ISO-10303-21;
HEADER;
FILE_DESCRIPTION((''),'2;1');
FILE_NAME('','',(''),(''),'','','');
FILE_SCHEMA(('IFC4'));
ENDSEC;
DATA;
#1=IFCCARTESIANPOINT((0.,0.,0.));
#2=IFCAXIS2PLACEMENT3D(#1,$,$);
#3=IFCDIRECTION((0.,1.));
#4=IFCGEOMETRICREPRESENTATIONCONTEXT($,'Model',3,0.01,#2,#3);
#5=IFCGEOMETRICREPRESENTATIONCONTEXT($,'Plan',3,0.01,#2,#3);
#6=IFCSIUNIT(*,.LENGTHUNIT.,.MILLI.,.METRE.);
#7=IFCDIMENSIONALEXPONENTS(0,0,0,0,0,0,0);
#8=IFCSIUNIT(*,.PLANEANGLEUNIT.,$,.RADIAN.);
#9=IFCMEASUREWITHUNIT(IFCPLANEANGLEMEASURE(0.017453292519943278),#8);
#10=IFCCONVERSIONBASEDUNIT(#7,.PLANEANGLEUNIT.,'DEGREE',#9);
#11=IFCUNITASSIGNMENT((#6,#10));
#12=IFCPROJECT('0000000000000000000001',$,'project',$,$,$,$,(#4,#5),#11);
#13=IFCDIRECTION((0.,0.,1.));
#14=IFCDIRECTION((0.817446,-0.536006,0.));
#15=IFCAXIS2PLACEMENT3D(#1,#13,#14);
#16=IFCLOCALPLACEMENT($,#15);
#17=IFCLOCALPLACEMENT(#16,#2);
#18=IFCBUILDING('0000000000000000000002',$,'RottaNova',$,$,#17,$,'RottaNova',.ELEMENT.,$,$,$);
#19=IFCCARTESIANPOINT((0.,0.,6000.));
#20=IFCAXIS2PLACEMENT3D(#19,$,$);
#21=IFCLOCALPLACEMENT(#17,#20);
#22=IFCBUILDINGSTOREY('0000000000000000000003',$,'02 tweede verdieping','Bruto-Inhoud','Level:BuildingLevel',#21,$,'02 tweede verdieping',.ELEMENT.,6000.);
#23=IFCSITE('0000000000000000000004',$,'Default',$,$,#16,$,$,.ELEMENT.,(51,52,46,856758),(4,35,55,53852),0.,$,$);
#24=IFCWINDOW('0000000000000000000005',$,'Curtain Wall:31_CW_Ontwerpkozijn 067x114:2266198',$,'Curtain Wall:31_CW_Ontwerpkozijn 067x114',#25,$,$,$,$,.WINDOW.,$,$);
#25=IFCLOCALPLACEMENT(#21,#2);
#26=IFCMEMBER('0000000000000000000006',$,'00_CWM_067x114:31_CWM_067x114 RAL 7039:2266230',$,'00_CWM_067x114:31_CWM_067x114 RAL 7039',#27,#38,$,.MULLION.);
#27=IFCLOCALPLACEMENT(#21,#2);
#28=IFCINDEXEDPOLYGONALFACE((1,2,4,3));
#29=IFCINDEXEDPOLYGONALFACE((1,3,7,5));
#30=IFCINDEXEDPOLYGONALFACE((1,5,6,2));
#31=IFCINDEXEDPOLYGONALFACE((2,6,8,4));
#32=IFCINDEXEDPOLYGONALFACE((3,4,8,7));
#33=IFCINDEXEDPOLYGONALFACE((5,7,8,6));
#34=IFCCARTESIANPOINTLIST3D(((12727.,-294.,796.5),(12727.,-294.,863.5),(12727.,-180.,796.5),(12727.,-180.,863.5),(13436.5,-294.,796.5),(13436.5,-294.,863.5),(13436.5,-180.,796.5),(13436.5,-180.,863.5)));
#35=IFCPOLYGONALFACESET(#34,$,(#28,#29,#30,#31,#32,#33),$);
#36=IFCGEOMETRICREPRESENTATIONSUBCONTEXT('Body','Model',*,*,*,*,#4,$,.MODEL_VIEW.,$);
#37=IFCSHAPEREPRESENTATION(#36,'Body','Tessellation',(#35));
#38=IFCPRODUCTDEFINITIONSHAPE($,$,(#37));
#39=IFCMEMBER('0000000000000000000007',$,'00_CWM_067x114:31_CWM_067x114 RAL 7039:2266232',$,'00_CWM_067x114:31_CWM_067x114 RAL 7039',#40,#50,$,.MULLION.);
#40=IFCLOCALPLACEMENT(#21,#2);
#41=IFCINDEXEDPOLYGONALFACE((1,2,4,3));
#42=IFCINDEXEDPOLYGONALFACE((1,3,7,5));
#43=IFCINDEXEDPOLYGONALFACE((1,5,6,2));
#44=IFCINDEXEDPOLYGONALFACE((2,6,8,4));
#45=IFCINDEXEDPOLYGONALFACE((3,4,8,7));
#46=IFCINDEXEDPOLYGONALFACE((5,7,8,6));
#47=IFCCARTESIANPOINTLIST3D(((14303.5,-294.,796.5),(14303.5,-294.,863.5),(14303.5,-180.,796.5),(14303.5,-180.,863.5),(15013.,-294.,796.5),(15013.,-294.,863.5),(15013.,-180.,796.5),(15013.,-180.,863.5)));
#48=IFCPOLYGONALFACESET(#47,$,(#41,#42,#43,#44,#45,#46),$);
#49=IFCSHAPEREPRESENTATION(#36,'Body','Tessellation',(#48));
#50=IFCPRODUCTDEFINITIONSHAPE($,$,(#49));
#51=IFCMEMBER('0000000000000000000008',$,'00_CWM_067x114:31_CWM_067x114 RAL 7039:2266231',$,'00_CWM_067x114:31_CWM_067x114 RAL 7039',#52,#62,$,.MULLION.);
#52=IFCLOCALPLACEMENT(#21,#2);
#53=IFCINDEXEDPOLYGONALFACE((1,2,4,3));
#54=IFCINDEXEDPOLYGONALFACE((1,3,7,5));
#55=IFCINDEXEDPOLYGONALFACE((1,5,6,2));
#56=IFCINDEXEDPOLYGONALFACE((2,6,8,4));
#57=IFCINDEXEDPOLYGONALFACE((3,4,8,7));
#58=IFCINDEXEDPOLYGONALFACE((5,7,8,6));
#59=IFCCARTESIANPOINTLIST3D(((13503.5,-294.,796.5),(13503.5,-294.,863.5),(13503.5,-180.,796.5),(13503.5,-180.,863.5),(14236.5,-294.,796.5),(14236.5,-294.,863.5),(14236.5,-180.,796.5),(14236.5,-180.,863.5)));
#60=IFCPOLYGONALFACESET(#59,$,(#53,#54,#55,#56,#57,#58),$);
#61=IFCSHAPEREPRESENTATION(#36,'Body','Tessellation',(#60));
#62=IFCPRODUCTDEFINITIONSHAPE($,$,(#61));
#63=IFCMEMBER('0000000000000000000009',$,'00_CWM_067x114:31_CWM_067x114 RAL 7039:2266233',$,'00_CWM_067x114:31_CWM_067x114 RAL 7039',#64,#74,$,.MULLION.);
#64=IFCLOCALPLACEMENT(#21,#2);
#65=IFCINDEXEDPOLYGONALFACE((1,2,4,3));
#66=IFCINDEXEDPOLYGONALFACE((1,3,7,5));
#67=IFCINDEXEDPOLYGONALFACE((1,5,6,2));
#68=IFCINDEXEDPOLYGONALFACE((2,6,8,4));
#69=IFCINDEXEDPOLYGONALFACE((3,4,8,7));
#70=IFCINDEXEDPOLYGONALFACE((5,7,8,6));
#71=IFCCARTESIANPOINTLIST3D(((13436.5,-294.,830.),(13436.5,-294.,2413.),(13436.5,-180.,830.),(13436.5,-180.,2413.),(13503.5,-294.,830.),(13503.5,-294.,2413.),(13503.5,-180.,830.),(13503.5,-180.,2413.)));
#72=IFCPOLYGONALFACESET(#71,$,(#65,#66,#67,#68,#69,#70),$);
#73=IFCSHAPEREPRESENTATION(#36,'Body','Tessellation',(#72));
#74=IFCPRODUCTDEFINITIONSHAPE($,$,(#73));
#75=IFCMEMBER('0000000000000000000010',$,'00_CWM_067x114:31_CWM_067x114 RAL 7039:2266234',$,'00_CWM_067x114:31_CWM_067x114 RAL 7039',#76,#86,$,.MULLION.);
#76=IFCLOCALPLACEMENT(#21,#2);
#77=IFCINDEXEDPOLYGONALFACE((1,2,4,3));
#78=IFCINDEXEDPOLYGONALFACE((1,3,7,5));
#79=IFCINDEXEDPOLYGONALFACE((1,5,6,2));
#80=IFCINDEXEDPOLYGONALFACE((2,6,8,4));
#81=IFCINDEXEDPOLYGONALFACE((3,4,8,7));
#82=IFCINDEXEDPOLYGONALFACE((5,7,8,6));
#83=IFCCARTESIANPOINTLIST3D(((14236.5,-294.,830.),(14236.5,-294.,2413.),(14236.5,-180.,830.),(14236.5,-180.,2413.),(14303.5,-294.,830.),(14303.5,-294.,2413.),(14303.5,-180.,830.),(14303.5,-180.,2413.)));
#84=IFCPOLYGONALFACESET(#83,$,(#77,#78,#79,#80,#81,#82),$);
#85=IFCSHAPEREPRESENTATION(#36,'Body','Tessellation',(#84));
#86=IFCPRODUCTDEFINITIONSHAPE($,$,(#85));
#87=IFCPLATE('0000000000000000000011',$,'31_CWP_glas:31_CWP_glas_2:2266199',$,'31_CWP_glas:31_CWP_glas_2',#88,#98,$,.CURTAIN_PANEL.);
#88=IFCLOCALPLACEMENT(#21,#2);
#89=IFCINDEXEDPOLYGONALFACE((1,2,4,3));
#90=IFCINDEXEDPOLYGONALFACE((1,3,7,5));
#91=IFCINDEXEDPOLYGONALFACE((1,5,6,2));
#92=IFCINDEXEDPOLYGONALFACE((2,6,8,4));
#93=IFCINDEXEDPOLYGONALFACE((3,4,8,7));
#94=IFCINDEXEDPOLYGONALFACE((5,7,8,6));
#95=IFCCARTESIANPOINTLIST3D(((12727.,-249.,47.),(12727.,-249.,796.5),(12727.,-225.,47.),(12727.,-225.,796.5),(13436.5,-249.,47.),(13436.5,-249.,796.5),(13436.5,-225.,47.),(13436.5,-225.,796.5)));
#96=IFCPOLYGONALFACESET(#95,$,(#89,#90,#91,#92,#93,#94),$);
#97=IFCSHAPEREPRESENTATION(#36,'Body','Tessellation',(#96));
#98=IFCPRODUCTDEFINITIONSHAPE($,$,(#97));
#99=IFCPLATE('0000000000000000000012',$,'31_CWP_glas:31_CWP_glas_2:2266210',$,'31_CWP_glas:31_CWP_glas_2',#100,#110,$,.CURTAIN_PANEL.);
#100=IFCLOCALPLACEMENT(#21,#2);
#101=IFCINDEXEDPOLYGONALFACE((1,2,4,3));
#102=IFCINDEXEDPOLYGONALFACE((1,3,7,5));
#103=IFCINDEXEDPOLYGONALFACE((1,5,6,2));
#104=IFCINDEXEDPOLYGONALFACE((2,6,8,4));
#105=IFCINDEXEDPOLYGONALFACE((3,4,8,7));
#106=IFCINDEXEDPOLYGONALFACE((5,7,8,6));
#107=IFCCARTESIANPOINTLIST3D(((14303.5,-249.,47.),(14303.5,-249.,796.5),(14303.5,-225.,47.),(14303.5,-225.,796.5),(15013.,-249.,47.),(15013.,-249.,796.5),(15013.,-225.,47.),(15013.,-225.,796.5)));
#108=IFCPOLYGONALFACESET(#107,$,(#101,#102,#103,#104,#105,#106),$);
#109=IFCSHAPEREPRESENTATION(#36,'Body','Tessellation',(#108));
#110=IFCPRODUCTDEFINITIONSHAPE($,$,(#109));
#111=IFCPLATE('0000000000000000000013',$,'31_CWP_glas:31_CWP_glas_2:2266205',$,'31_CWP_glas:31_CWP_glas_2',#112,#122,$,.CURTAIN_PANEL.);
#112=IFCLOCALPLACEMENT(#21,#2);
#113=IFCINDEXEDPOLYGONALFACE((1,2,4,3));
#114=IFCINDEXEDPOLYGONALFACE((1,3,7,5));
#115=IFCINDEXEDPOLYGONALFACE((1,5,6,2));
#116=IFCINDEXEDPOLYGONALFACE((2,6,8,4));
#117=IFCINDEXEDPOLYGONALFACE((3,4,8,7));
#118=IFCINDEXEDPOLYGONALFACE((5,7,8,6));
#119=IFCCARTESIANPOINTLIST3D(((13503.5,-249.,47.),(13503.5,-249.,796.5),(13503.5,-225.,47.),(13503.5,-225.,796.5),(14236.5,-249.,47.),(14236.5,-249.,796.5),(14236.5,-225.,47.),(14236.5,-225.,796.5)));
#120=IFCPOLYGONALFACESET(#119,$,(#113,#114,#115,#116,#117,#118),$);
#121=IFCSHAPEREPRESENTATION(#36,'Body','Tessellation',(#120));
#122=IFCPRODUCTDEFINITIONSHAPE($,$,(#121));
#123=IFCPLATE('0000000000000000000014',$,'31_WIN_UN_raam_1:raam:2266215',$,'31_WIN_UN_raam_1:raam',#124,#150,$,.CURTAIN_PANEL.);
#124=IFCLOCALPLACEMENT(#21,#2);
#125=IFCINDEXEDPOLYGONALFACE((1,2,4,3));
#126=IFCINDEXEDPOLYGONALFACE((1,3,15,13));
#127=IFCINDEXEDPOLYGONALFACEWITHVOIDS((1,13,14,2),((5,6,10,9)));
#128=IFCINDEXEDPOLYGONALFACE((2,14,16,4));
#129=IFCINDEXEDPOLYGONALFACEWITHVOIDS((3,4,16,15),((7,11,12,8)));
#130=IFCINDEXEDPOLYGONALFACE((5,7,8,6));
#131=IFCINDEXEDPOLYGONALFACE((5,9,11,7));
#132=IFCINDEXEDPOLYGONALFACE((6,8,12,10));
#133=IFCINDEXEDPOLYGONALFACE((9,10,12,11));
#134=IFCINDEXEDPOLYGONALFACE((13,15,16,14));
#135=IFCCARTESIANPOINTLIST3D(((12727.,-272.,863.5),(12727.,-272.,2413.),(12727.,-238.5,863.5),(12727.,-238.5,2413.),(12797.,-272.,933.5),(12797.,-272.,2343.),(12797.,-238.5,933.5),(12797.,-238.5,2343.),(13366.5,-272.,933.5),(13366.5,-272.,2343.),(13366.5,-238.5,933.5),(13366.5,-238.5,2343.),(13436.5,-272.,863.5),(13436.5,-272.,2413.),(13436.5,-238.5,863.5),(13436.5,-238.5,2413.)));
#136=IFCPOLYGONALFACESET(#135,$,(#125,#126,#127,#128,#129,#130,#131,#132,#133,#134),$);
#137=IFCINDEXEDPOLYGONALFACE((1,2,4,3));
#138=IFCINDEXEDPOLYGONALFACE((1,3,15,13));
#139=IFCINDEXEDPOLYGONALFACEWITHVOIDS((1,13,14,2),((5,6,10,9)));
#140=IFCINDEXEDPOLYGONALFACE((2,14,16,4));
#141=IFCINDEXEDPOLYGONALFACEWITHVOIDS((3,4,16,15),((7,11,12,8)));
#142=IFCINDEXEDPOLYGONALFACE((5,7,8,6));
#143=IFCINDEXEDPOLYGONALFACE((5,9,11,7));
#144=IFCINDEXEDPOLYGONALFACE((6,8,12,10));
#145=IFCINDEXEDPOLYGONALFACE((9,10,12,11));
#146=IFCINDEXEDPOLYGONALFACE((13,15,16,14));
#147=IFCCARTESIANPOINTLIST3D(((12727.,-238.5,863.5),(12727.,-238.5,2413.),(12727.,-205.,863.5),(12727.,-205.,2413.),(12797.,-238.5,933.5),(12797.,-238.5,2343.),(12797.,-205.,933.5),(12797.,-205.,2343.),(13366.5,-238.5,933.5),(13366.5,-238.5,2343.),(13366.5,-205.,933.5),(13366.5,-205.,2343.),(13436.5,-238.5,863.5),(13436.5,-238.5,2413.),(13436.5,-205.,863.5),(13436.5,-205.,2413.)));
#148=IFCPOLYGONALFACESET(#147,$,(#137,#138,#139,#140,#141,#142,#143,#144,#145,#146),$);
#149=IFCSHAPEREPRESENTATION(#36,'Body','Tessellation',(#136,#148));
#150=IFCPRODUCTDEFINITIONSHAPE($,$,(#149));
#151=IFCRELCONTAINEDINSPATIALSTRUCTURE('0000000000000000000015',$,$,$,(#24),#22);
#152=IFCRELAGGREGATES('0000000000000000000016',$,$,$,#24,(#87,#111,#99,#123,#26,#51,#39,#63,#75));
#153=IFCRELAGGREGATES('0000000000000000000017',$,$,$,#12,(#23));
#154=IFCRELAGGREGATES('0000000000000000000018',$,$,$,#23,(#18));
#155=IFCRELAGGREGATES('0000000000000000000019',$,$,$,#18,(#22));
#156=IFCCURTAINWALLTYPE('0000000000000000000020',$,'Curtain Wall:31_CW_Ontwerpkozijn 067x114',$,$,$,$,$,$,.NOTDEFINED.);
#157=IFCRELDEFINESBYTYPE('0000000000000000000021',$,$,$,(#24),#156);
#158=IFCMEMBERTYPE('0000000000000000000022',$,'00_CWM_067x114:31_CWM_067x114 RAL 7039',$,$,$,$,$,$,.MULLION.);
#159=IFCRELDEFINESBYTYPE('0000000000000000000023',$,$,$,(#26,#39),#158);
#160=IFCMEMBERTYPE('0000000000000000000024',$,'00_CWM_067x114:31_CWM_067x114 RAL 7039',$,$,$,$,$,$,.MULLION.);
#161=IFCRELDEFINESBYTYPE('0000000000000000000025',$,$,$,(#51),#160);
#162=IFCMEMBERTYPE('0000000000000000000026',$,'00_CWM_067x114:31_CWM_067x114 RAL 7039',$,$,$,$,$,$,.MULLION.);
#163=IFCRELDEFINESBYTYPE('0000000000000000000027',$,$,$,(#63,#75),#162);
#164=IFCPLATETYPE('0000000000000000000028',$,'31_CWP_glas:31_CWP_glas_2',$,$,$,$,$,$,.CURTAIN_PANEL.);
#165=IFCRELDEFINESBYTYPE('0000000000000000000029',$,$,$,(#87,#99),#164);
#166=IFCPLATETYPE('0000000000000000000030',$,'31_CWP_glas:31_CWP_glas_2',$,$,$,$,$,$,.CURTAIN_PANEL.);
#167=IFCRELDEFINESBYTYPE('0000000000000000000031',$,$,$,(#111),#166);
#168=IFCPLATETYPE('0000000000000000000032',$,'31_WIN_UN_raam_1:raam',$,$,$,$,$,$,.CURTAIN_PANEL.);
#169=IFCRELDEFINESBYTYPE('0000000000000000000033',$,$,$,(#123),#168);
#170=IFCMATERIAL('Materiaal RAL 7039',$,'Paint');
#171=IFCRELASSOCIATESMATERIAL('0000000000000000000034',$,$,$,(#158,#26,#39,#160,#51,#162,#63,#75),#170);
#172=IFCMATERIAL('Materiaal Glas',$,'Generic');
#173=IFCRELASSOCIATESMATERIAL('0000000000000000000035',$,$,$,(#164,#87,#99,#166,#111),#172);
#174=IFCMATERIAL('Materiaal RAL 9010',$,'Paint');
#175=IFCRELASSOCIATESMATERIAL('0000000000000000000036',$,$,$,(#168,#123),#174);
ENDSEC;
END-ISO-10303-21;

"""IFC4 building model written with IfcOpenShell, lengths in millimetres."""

from ifc_helpers import new_model, entity, si_unit, converted_unit, direction, frame, origin, place, context, subcontext, project, spatial, indexed_curve, outline, extrude, source, transform, mapped, material, type_object, type_shapes, element, aggregate, save


model = new_model("IFC4")

# Units and contexts
model_context = context("Model", 3, precision=0.01, world=origin(), true_north=direction((0.0, 1.0)))
plan_context = context("Plan", 3, precision=0.01, world=origin(), true_north=direction((0.0, 1.0)))
body_context = subcontext(model_context, "Body", "Model", "MODEL_VIEW")
ifc_project = project(units=[si_unit("LENGTHUNIT", "METRE", prefix="MILLI"), converted_unit("PLANEANGLEUNIT", "DEGREE", entity("IfcPlaneAngleMeasure", 0.017453292519943278), si_unit("PLANEANGLEUNIT", "RADIAN"), dimensions=[0, 0, 0, 0, 0, 0, 0])], contexts=[model_context, plan_context])

# Site, building, storey
site_placement = place(None, frame((0.0, 0.0, 0.0), z_axis=(0.0, 0.0, 1.0), x_axis=(0.817446, -0.536006, 0.0)))
site = spatial("IfcSite", under=ifc_project, at=site_placement, Name="Default", CompositionType="ELEMENT", RefLatitude=(51, 52, 46, 856758), RefLongitude=(4, 35, 55, 53852), RefElevation=0.0)
building_placement = place(site_placement, origin())
building = spatial("IfcBuilding", under=site, at=building_placement, Name="RottaNova", LongName="RottaNova", CompositionType="ELEMENT")
storey_placement = place(building_placement, frame((0.0, 0.0, 6000.0)))
storey = spatial("IfcBuildingStorey", under=building, at=storey_placement, Name="02 tweede verdieping", Description="Bruto-Inhoud", ObjectType="Level:BuildingLevel", LongName="02 tweede verdieping", CompositionType="ELEMENT", Elevation=6000.0)

# Window, members, plates
curtain_wall_type = type_object("IfcCurtainWallType", Name="Curtain Wall:31_CW_Ontwerpkozijn 067x114", PredefinedType="NOTDEFINED")
window_1_placement = place(storey_placement, frame((0.0, 0.0, -6000.0)))
window_1 = element("IfcWindow", 1, at=window_1_placement, inside=storey, type_object=curtain_wall_type, Name="Curtain Wall:31_CW_Ontwerpkozijn 067x114:2266198", ObjectType="Curtain Wall:31_CW_Ontwerpkozijn 067x114", PredefinedType="WINDOW")
ifc_material_1 = material(Name="Materiaal RAL 7039", Category="Paint")
member_type_1 = type_object("IfcMemberType", Name="00_CWM_067x114:31_CWM_067x114 RAL 7039", PredefinedType="MULLION", material=ifc_material_1)
shared_shape_1 = source(origin(), body_context, "Body", "SweptSolid", [
    extrude(outline(indexed_curve([(-33.5, -57.0), (33.5, -57.0), (33.5, 57.0), (-33.5, 57.0), (-33.5, -57.0)], self_intersect=False)), frame((0.0, 57.0, -709.5), z_axis=(0.0, 0.0, 1.0), x_axis=(-1.0, 0.0, 0.0)), (0.0, 0.0, 1.0), 709.5),
])
type_shapes(member_type_1, [shared_shape_1])
member_1_placement = place(window_1_placement, frame((13436.5, -180.0, 6830.0), z_axis=(1.0, 0.0, 0.0), x_axis=(0.0, 0.0, 1.0)))
member_1 = element("IfcMember", 2, at=member_1_placement, type_object=member_type_1, material=ifc_material_1, Name="00_CWM_067x114:31_CWM_067x114 RAL 7039:2266230", ObjectType="00_CWM_067x114:31_CWM_067x114 RAL 7039", PredefinedType="MULLION", context=body_context, shape_type="MappedRepresentation", body=[
    mapped(shared_shape_1, transform((0.0, 0.0, 0.0), scale=1.0)),
])
member_2_placement = place(window_1_placement, frame((15013.0, -180.0, 6830.0), z_axis=(1.0, 0.0, 0.0), x_axis=(0.0, 0.0, 1.0)))
member_2 = element("IfcMember", 3, at=member_2_placement, type_object=member_type_1, material=ifc_material_1, Name="00_CWM_067x114:31_CWM_067x114 RAL 7039:2266232", ObjectType="00_CWM_067x114:31_CWM_067x114 RAL 7039", PredefinedType="MULLION", context=body_context, shape_type="MappedRepresentation", body=[
    mapped(shared_shape_1, transform((0.0, 0.0, 0.0), scale=1.0)),
])
member_type_2 = type_object("IfcMemberType", Name="00_CWM_067x114:31_CWM_067x114 RAL 7039", PredefinedType="MULLION", material=ifc_material_1)
shared_shape_2 = source(origin(), body_context, "Body", "SweptSolid", [
    extrude(outline(indexed_curve([(-33.5, -57.0), (33.5, -57.0), (33.5, 57.0), (-33.5, 57.0), (-33.5, -57.0)], self_intersect=False)), frame((0.0, 57.0, -733.0), z_axis=(0.0, 0.0, 1.0), x_axis=(-1.0, 0.0, 0.0)), (0.0, 0.0, 1.0), 733.0),
])
type_shapes(member_type_2, [shared_shape_2])
member_3_placement = place(window_1_placement, frame((14236.5, -180.0, 6830.0), z_axis=(1.0, 0.0, 0.0), x_axis=(0.0, 0.0, 1.0)))
member_3 = element("IfcMember", 4, at=member_3_placement, type_object=member_type_2, material=ifc_material_1, Name="00_CWM_067x114:31_CWM_067x114 RAL 7039:2266231", ObjectType="00_CWM_067x114:31_CWM_067x114 RAL 7039", PredefinedType="MULLION", context=body_context, shape_type="MappedRepresentation", body=[
    mapped(shared_shape_2, transform((0.0, 0.0, 0.0), scale=1.0)),
])
member_type_3 = type_object("IfcMemberType", Name="00_CWM_067x114:31_CWM_067x114 RAL 7039", PredefinedType="MULLION", material=ifc_material_1)
shared_shape_3 = source(origin(), body_context, "Body", "SweptSolid", [
    extrude(outline(indexed_curve([(-33.5, -57.0), (33.5, -57.0), (33.5, 57.0), (-33.5, 57.0), (-33.5, -57.0)], self_intersect=False)), frame((0.0, 57.0, -1583.0), z_axis=(0.0, 0.0, 1.0), x_axis=(-1.0, 0.0, 0.0)), (0.0, 0.0, 1.0), 1583.0),
])
type_shapes(member_type_3, [shared_shape_3])
member_4_placement = place(window_1_placement, frame((13470.0, -180.0, 6830.0), z_axis=(0.0, 0.0, -1.0), x_axis=(1.0, 0.0, 0.0)))
member_4 = element("IfcMember", 5, at=member_4_placement, type_object=member_type_3, material=ifc_material_1, Name="00_CWM_067x114:31_CWM_067x114 RAL 7039:2266233", ObjectType="00_CWM_067x114:31_CWM_067x114 RAL 7039", PredefinedType="MULLION", context=body_context, shape_type="MappedRepresentation", body=[
    mapped(shared_shape_3, transform((0.0, 0.0, 0.0), scale=1.0)),
])
member_5_placement = place(window_1_placement, frame((14270.0, -180.0, 6830.0), z_axis=(0.0, 0.0, -1.0), x_axis=(1.0, 0.0, 0.0)))
member_5 = element("IfcMember", 6, at=member_5_placement, type_object=member_type_3, material=ifc_material_1, Name="00_CWM_067x114:31_CWM_067x114 RAL 7039:2266234", ObjectType="00_CWM_067x114:31_CWM_067x114 RAL 7039", PredefinedType="MULLION", context=body_context, shape_type="MappedRepresentation", body=[
    mapped(shared_shape_3, transform((0.0, 0.0, 0.0), scale=1.0)),
])
ifc_material_2 = material(Name="Materiaal Glas", Category="Generic")
plate_type_1 = type_object("IfcPlateType", Name="31_CWP_glas:31_CWP_glas_2", PredefinedType="CURTAIN_PANEL", material=ifc_material_2)
shared_shape_4 = source(origin(), body_context, "Body", "SweptSolid", [
    extrude(outline(indexed_curve([(-12.0, -354.8), (12.0, -354.8), (12.0, 354.8), (-12.0, 354.8), (-12.0, -354.8)], self_intersect=False)), frame((0.0, -57.0, 0.0), z_axis=(0.0, 0.0, 1.0), x_axis=(0.0, 1.0, 0.0)), (0.0, 0.0, 1.0), 749.5),
])
type_shapes(plate_type_1, [shared_shape_4])
plate_1_placement = place(window_1_placement, frame((13081.8, -180.0, 6047.0)))
plate_1 = element("IfcPlate", 7, at=plate_1_placement, type_object=plate_type_1, material=ifc_material_2, Name="31_CWP_glas:31_CWP_glas_2:2266199", ObjectType="31_CWP_glas:31_CWP_glas_2", PredefinedType="CURTAIN_PANEL", context=body_context, shape_type="MappedRepresentation", body=[
    mapped(shared_shape_4, transform((0.0, 0.0, 0.0), scale=1.0)),
])
plate_2_placement = place(window_1_placement, frame((14658.3, -180.0, 6047.0)))
plate_2 = element("IfcPlate", 8, at=plate_2_placement, type_object=plate_type_1, material=ifc_material_2, Name="31_CWP_glas:31_CWP_glas_2:2266210", ObjectType="31_CWP_glas:31_CWP_glas_2", PredefinedType="CURTAIN_PANEL", context=body_context, shape_type="MappedRepresentation", body=[
    mapped(shared_shape_4, transform((0.0, 0.0, 0.0), scale=1.0)),
])
plate_type_2 = type_object("IfcPlateType", Name="31_CWP_glas:31_CWP_glas_2", PredefinedType="CURTAIN_PANEL", material=ifc_material_2)
shared_shape_5 = source(origin(), body_context, "Body", "SweptSolid", [
    extrude(outline(indexed_curve([(-12.0, -366.5), (12.0, -366.5), (12.0, 366.5), (-12.0, 366.5), (-12.0, -366.5)], self_intersect=False)), frame((0.0, -57.0, 0.0), z_axis=(0.0, 0.0, 1.0), x_axis=(0.0, 1.0, 0.0)), (0.0, 0.0, 1.0), 749.5),
])
type_shapes(plate_type_2, [shared_shape_5])
plate_3_placement = place(window_1_placement, frame((13870.0, -180.0, 6047.0)))
plate_3 = element("IfcPlate", 9, at=plate_3_placement, type_object=plate_type_2, material=ifc_material_2, Name="31_CWP_glas:31_CWP_glas_2:2266205", ObjectType="31_CWP_glas:31_CWP_glas_2", PredefinedType="CURTAIN_PANEL", context=body_context, shape_type="MappedRepresentation", body=[
    mapped(shared_shape_5, transform((0.0, 0.0, 0.0), scale=1.0)),
])
ifc_material_3 = material(Name="Materiaal RAL 9010", Category="Paint")
plate_type_3 = type_object("IfcPlateType", Name="31_WIN_UN_raam_1:raam", PredefinedType="CURTAIN_PANEL", material=ifc_material_3)
shared_shape_6 = source(origin(), body_context, "Body", "SweptSolid", [
    extrude(outline(indexed_curve([(-354.7, -774.7), (354.7, -774.7), (354.7, 774.7), (-354.7, 774.7), (-354.7, -774.7)], self_intersect=False), holes=[indexed_curve([(-284.7, 704.7), (284.7, 704.7), (284.7, -704.8), (-284.7, -704.8), (-284.7, 704.7)], self_intersect=False)]), frame((0.0, -92.0, 774.8), z_axis=(0.0, 1.0, 0.0), x_axis=(1.0, 0.0, 0.0)), (0.0, 0.0, 1.0), 33.5),
    extrude(outline(indexed_curve([(-354.7, -774.7), (354.7, -774.7), (354.7, 774.7), (-354.7, 774.7), (-354.7, -774.7)], self_intersect=False), holes=[indexed_curve([(-284.7, 704.7), (284.7, 704.7), (284.7, -704.8), (-284.7, -704.8), (-284.7, 704.7)], self_intersect=False)]), frame((0.0, -58.5, 774.8), z_axis=(0.0, 1.0, 0.0), x_axis=(1.0, 0.0, 0.0)), (0.0, 0.0, 1.0), 33.5),
])
type_shapes(plate_type_3, [shared_shape_6])
plate_4_placement = place(window_1_placement, frame((13081.8, -180.0, 6863.5)))
plate_4 = element("IfcPlate", 10, at=plate_4_placement, type_object=plate_type_3, material=ifc_material_3, Name="31_WIN_UN_raam_1:raam:2266215", ObjectType="31_WIN_UN_raam_1:raam", PredefinedType="CURTAIN_PANEL", context=body_context, shape_type="MappedRepresentation", body=[
    mapped(shared_shape_6, transform((0.0, 0.0, 0.0), scale=1.0)),
])
aggregate(window_1, [plate_1, plate_3, plate_2, plate_4, member_1, member_3, member_2, member_4, member_5])

save(model, "model.ifc")
